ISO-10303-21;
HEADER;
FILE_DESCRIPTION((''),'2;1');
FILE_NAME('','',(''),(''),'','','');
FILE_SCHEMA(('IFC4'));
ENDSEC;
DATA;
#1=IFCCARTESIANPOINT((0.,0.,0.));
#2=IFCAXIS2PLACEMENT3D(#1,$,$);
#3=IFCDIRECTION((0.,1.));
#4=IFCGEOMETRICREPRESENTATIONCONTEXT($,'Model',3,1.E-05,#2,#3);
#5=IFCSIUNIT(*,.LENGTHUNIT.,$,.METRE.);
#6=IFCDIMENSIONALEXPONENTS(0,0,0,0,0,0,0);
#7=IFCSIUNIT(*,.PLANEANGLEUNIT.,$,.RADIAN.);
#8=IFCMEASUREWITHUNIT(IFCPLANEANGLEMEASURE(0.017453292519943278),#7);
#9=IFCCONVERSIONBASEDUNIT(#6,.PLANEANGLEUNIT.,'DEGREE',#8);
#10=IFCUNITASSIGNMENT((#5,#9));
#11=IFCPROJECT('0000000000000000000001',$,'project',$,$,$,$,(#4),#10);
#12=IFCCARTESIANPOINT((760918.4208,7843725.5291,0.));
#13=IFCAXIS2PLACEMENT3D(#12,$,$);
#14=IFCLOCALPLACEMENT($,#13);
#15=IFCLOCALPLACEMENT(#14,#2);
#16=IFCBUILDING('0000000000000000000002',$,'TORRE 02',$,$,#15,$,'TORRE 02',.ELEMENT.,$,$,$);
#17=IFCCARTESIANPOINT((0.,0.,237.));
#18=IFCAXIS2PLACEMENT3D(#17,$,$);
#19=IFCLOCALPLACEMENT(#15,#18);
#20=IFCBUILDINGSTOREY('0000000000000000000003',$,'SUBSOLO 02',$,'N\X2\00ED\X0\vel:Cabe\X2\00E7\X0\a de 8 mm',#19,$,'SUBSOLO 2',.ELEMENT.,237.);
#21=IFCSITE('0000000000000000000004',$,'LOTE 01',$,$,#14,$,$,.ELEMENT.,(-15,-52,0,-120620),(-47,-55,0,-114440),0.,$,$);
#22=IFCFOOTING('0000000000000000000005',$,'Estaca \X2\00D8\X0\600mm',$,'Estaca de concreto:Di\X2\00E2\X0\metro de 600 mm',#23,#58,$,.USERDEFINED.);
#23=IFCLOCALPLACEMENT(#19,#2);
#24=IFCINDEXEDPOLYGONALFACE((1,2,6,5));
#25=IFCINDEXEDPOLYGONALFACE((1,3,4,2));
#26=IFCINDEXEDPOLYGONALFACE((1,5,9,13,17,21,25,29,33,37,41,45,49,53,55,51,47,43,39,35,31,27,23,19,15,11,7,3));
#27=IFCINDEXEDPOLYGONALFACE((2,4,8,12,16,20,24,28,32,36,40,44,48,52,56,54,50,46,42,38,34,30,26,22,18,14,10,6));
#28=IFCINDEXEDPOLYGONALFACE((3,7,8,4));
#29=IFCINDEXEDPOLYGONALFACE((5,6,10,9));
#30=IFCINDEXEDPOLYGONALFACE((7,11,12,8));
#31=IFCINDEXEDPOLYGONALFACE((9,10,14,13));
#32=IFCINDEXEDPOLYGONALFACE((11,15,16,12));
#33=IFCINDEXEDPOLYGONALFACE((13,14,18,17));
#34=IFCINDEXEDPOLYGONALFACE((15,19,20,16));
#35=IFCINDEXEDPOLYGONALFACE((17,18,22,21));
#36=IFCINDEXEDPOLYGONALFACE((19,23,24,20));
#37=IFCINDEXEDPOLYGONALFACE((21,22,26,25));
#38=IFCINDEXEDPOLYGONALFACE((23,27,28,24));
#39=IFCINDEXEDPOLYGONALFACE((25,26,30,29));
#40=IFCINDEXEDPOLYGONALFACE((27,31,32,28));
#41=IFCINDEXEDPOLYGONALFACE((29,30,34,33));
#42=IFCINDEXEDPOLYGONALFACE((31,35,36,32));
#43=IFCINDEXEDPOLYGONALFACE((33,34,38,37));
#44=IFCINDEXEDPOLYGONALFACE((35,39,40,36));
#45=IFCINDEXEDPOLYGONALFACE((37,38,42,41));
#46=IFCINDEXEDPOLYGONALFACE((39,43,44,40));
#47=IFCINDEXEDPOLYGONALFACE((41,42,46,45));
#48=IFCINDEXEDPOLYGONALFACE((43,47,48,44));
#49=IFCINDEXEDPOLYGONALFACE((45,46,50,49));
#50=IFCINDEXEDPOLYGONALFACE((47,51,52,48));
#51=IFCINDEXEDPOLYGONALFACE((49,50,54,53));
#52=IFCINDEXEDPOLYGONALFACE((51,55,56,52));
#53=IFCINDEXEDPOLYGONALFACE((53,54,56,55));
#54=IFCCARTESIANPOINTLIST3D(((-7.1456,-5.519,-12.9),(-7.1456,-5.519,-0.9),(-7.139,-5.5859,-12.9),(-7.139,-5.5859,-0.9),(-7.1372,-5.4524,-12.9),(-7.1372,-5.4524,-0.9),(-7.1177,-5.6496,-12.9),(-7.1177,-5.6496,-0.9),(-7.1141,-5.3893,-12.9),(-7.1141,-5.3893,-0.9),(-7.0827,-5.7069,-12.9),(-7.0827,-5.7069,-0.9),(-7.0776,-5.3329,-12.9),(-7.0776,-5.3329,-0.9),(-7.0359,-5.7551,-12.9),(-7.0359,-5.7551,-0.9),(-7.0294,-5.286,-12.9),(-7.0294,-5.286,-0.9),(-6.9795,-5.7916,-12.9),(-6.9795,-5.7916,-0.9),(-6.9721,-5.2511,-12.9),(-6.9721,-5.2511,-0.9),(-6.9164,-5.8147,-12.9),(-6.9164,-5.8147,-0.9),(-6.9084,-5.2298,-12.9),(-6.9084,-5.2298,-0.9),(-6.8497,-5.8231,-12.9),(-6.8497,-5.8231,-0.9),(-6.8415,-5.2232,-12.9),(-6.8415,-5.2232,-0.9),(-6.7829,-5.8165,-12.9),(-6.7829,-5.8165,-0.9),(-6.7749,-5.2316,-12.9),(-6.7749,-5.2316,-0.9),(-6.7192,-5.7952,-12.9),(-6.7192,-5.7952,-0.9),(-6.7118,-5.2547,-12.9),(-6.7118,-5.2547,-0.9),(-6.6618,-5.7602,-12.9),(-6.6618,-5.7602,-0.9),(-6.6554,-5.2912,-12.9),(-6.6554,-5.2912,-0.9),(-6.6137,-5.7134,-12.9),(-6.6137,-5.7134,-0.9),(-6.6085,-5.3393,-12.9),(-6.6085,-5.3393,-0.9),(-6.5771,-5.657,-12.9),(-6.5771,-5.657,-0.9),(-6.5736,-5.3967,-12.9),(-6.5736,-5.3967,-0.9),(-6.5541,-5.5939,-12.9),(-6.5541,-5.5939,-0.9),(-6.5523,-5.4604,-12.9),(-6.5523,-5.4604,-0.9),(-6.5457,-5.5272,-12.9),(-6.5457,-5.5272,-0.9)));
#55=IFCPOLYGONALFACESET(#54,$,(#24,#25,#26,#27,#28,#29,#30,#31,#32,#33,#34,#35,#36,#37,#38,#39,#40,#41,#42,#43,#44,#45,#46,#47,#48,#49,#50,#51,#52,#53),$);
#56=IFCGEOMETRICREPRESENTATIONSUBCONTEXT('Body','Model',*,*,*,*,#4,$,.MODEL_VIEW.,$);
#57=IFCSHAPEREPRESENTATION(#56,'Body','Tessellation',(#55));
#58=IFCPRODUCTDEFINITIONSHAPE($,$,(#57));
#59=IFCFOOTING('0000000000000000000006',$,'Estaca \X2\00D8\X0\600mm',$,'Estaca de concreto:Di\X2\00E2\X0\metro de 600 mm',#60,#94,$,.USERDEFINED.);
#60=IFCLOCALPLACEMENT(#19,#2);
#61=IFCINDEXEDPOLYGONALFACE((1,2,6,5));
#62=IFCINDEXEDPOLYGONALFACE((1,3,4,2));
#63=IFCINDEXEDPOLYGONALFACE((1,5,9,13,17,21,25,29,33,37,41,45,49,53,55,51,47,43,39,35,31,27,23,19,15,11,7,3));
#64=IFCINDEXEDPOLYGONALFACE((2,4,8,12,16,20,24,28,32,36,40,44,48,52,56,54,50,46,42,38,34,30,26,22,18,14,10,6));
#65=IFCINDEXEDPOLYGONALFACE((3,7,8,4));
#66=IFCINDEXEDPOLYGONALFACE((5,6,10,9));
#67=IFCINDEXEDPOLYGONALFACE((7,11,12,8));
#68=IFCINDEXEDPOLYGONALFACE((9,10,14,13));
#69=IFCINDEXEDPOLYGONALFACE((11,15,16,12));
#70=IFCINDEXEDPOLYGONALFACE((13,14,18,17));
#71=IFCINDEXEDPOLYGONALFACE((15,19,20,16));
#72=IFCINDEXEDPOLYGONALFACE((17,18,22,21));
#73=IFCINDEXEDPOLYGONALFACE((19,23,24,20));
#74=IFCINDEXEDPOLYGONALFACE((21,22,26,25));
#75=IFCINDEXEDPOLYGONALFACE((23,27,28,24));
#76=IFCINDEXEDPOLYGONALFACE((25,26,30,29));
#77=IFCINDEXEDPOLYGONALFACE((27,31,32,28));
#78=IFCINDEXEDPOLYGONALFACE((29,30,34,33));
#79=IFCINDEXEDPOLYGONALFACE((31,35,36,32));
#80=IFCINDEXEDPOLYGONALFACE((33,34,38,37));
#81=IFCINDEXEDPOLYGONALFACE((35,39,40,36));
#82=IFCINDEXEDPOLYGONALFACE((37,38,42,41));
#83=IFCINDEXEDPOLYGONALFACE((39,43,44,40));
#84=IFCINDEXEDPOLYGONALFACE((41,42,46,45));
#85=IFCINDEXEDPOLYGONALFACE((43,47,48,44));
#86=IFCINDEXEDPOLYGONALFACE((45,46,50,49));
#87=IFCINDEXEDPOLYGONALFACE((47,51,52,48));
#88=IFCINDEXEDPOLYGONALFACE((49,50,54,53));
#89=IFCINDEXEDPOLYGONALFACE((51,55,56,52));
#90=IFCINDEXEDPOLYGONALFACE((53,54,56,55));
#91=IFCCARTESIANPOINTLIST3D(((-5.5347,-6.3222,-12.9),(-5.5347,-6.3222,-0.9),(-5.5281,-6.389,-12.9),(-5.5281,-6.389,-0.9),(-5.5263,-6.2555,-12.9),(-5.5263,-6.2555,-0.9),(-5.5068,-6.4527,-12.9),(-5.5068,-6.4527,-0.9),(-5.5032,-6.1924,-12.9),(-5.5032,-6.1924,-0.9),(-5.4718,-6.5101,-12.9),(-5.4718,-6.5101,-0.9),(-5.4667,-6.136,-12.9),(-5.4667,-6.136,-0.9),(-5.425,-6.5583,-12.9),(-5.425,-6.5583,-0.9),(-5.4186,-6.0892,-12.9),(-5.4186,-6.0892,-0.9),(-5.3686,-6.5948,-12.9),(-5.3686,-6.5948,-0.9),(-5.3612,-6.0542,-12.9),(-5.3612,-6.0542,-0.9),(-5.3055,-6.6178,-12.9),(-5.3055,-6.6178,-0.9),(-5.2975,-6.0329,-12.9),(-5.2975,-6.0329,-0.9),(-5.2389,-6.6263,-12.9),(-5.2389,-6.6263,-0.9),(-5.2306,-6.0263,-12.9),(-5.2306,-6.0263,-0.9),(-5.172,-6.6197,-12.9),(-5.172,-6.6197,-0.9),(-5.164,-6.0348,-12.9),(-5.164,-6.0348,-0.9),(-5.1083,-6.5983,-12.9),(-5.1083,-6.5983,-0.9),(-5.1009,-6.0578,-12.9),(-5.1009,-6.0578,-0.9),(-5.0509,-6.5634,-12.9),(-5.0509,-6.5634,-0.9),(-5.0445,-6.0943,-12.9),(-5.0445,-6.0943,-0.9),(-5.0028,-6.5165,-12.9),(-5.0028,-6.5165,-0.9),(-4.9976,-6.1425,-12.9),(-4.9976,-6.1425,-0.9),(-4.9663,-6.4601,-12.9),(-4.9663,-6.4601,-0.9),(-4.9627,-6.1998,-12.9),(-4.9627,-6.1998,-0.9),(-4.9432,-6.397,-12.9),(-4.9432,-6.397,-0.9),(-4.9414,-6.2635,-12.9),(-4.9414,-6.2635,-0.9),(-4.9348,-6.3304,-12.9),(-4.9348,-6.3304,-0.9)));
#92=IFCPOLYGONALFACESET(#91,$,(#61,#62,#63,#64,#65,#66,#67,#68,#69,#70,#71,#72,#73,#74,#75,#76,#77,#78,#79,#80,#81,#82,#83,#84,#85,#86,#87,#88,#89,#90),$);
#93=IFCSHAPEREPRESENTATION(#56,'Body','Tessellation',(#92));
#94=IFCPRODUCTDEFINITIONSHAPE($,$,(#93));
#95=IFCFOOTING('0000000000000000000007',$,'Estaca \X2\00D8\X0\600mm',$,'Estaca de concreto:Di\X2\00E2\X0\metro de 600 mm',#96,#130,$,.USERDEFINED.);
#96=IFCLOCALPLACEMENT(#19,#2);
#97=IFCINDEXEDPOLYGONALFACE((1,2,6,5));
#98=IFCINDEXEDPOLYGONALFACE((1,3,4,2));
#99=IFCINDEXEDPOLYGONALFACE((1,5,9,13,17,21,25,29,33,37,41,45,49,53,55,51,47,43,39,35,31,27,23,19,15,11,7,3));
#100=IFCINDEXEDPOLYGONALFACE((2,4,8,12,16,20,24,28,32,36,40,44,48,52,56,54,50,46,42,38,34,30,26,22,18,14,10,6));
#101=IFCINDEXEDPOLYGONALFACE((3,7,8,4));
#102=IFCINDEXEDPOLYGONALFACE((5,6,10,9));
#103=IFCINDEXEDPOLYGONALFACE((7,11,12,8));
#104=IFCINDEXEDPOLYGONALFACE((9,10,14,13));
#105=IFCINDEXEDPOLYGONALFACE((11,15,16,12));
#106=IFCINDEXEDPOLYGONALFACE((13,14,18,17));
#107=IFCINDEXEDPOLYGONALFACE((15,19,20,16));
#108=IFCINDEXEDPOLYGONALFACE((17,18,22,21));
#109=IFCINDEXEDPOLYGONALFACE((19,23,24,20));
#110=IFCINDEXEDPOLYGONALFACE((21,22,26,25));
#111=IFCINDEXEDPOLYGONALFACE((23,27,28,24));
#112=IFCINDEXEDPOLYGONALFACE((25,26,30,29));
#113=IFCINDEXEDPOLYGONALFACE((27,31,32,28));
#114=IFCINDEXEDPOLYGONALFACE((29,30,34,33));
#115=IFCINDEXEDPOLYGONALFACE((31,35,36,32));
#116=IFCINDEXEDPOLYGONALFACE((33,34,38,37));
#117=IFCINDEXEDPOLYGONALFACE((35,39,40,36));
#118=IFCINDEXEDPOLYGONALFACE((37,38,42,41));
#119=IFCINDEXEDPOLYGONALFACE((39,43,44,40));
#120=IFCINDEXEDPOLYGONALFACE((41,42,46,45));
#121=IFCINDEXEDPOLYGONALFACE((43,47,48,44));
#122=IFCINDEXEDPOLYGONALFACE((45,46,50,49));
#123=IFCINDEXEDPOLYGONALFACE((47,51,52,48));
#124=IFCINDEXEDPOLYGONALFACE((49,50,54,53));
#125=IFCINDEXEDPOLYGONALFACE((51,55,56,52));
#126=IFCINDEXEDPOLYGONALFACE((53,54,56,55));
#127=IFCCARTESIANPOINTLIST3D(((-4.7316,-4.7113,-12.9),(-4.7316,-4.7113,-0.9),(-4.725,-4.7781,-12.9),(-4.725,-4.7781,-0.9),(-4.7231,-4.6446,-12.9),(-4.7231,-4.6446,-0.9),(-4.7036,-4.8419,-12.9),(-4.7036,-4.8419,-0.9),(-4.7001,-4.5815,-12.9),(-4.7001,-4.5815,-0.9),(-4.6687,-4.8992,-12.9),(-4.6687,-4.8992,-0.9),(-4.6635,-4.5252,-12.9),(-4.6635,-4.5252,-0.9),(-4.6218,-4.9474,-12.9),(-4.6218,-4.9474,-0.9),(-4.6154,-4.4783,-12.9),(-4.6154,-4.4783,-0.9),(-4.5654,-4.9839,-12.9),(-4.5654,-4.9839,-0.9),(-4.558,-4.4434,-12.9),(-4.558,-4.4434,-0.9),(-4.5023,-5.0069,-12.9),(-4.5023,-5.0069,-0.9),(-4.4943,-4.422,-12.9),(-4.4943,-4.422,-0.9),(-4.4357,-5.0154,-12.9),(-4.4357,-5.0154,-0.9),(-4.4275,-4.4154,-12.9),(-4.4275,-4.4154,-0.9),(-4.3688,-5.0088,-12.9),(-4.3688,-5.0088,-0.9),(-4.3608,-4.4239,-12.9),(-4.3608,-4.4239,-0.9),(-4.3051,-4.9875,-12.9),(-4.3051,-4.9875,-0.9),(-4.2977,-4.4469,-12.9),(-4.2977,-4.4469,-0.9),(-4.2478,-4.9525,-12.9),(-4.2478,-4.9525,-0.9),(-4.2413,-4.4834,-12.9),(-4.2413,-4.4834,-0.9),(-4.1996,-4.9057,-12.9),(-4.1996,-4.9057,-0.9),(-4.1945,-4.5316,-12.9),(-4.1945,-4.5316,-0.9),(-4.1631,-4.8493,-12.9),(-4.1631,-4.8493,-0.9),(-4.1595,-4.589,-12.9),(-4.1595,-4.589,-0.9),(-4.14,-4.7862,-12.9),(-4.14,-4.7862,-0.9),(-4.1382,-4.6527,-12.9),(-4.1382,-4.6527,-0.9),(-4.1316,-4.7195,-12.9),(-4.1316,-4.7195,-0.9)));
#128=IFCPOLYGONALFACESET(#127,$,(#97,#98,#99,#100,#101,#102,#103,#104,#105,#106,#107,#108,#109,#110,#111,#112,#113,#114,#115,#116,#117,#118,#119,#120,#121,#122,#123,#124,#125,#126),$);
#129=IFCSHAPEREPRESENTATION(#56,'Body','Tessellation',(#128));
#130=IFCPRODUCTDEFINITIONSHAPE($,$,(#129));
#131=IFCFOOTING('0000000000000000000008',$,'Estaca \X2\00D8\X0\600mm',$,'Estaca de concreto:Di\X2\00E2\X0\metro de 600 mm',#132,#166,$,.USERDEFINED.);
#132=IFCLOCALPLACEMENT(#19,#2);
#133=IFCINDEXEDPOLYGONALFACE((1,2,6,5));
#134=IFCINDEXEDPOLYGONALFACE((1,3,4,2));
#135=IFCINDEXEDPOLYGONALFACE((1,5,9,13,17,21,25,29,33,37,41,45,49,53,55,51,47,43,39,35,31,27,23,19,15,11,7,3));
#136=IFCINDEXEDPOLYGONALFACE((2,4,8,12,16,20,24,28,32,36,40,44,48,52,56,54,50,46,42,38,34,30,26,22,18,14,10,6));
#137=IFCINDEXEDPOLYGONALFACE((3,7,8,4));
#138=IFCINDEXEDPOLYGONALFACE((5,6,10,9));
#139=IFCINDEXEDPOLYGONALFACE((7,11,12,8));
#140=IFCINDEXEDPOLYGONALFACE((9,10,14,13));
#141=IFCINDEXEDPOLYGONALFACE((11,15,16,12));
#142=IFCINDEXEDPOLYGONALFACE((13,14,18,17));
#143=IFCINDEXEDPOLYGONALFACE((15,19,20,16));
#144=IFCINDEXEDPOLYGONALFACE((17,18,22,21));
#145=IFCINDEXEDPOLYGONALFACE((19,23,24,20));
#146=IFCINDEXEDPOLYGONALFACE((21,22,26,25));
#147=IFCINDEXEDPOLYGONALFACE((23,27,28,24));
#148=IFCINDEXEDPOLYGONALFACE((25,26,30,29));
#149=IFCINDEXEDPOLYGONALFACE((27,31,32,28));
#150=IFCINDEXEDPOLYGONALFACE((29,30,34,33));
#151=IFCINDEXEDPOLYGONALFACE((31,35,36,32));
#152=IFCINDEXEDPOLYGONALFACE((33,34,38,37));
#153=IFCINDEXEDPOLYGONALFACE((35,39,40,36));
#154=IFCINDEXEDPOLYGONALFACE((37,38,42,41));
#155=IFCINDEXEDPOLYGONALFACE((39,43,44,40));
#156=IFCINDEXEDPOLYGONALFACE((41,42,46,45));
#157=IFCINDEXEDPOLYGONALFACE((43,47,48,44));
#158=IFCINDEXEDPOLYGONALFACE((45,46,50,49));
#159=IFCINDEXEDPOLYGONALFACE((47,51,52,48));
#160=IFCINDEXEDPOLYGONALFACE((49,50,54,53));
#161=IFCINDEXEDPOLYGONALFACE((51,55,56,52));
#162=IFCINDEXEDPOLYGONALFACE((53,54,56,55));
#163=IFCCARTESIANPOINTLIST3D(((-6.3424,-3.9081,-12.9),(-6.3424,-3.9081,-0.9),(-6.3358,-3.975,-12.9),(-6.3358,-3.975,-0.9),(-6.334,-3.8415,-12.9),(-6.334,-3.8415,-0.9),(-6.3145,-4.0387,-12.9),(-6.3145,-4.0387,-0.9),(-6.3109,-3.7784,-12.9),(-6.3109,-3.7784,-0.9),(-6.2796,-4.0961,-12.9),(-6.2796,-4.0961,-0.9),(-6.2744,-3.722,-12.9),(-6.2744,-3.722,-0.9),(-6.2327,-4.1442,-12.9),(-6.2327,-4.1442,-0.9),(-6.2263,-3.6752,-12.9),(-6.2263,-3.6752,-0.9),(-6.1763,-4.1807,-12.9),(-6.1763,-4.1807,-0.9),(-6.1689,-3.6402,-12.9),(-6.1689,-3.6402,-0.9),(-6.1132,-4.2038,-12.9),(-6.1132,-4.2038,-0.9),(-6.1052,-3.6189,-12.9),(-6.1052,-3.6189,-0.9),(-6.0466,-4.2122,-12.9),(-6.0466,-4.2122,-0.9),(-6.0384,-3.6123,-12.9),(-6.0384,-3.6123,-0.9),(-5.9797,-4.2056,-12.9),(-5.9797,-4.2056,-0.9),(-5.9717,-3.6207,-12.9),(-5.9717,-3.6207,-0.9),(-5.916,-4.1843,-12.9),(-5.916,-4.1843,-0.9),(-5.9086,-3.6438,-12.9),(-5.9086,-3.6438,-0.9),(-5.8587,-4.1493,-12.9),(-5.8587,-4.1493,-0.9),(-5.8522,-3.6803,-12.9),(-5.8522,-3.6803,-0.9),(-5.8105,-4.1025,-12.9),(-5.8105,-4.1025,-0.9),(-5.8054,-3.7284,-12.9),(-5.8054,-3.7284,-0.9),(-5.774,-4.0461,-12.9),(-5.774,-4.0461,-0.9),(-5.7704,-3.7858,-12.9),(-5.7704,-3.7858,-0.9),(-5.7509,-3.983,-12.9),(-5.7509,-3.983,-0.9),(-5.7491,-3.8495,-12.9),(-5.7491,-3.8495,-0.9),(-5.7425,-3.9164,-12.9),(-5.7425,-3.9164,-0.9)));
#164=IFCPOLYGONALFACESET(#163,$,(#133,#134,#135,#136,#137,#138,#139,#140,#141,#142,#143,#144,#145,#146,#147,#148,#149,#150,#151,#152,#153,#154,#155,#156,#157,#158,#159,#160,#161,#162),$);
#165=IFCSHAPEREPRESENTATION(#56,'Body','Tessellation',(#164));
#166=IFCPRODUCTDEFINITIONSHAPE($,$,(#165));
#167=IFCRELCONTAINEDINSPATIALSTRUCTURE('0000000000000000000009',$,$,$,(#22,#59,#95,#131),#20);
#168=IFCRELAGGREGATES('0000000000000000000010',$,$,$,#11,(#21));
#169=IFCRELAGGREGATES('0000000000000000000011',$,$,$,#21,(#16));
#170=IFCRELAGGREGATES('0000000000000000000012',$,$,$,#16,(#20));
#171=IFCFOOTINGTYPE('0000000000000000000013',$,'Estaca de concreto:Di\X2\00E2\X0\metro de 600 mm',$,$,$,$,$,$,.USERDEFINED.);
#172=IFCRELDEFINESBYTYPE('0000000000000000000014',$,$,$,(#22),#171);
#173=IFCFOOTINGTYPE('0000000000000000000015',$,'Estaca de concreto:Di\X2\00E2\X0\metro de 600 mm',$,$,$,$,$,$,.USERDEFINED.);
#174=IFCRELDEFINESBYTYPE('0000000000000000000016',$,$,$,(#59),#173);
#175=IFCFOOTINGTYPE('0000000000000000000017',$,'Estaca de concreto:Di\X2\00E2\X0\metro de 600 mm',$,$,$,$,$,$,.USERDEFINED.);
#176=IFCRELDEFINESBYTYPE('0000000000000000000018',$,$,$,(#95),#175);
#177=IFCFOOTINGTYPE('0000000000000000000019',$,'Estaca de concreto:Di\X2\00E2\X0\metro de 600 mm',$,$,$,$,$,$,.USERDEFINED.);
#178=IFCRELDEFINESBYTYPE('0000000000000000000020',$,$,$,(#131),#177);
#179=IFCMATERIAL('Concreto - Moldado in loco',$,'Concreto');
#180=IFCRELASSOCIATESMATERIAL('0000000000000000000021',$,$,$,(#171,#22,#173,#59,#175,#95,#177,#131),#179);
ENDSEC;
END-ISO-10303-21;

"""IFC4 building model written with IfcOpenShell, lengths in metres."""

from ifc_helpers import new_model, entity, si_unit, converted_unit, direction, frame, origin, place, context, subcontext, project, spatial, arc, indexed_curve, outline, extrude, source, transform, mapped, material, type_object, type_shapes, element, save


model = new_model("IFC4")

# Units and contexts
model_context = context("Model", 3, precision=1e-05, world=origin(), true_north=direction((0.0, 1.0)))
body_context = subcontext(model_context, "Body", "Model", "MODEL_VIEW")
ifc_project = project(units=[si_unit("LENGTHUNIT", "METRE"), converted_unit("PLANEANGLEUNIT", "DEGREE", entity("IfcPlaneAngleMeasure", 0.017453292519943278), si_unit("PLANEANGLEUNIT", "RADIAN"), dimensions=[0, 0, 0, 0, 0, 0, 0])], contexts=[model_context])

# Site, building, storey
site_placement = place(None, frame((760918.4208, 7843725.5291, 0.0)))
site = spatial("IfcSite", under=ifc_project, at=site_placement, Name="LOTE 01", CompositionType="ELEMENT", RefLatitude=(-15, -52, 0, -120620), RefLongitude=(-47, -55, 0, -114440), RefElevation=0.0)
building_placement = place(site_placement, origin())
building = spatial("IfcBuilding", under=site, at=building_placement, Name="TORRE 02", LongName="TORRE 02", CompositionType="ELEMENT")
storey_placement = place(building_placement, frame((0.0, 0.0, 237.0)))
storey = spatial("IfcBuildingStorey", under=building, at=storey_placement, Name="SUBSOLO 02", ObjectType="Nível:Cabeça de 8 mm", LongName="SUBSOLO 2", CompositionType="ELEMENT", Elevation=237.0)

# Footings
ifc_material_1 = material(Name="Concreto - Moldado in loco", Category="Concreto")
placement = place(building_placement, frame((0.0, 0.0, 237.0)))
footing_type_1 = type_object("IfcFootingType", Name="Estaca de concreto:Diâmetro de 600 mm", PredefinedType="USERDEFINED", material=ifc_material_1)
shared_shape_1 = source(origin(), body_context, "Body", "SweptSolid", [
    extrude(outline(indexed_curve([(-0.3, 0.0), (0.0, -0.3), (0.3, 0.0), (0.0, 0.3)], segments=[arc(1, 2, 3), arc(3, 4, 1)], self_intersect=False)), frame((-6.8456, -5.5231, -12.0), z_axis=(0.0, 0.0, 1.0), x_axis=(0.894934, -0.446198, 0.0)), (0.0, 0.0, 1.0), 12.0),
])
type_shapes(footing_type_1, [shared_shape_1])
footing_1_placement = place(placement, frame((0.0, 0.0, -0.9)))
element("IfcFooting", 1, at=footing_1_placement, inside=storey, type_object=footing_type_1, material=ifc_material_1, Name="Estaca Ø600mm", ObjectType="Estaca de concreto:Diâmetro de 600 mm", PredefinedType="USERDEFINED", context=body_context, shape_type="MappedRepresentation", body=[
    mapped(shared_shape_1, transform((0.0, 0.0, 0.0), scale=1.0)),
])
footing_type_2 = type_object("IfcFootingType", Name="Estaca de concreto:Diâmetro de 600 mm", PredefinedType="USERDEFINED", material=ifc_material_1)
shared_shape_2 = source(origin(), body_context, "Body", "SweptSolid", [
    extrude(outline(indexed_curve([(-0.3, 0.0), (0.0, -0.3), (0.3, 0.0), (0.0, 0.3)], segments=[arc(1, 2, 3), arc(3, 4, 1)], self_intersect=False)), frame((-5.2347, -6.3263, -12.0), z_axis=(0.0, 0.0, 1.0), x_axis=(0.894934, -0.446198, 0.0)), (0.0, 0.0, 1.0), 12.0),
])
type_shapes(footing_type_2, [shared_shape_2])
footing_2_placement = place(placement, frame((0.0, 0.0, -0.9)))
element("IfcFooting", 2, at=footing_2_placement, inside=storey, type_object=footing_type_2, material=ifc_material_1, Name="Estaca Ø600mm", ObjectType="Estaca de concreto:Diâmetro de 600 mm", PredefinedType="USERDEFINED", context=body_context, shape_type="MappedRepresentation", body=[
    mapped(shared_shape_2, transform((0.0, 0.0, 0.0), scale=1.0)),
])
footing_type_3 = type_object("IfcFootingType", Name="Estaca de concreto:Diâmetro de 600 mm", PredefinedType="USERDEFINED", material=ifc_material_1)
shared_shape_3 = source(origin(), body_context, "Body", "SweptSolid", [
    extrude(outline(indexed_curve([(-0.3, 0.0), (0.0, -0.3), (0.3, 0.0), (0.0, 0.3)], segments=[arc(1, 2, 3), arc(3, 4, 1)], self_intersect=False)), frame((-4.4316, -4.7154, -12.0), z_axis=(0.0, 0.0, 1.0), x_axis=(0.894934, -0.446198, 0.0)), (0.0, 0.0, 1.0), 12.0),
])
type_shapes(footing_type_3, [shared_shape_3])
footing_3_placement = place(placement, frame((0.0, 0.0, -0.9)))
element("IfcFooting", 3, at=footing_3_placement, inside=storey, type_object=footing_type_3, material=ifc_material_1, Name="Estaca Ø600mm", ObjectType="Estaca de concreto:Diâmetro de 600 mm", PredefinedType="USERDEFINED", context=body_context, shape_type="MappedRepresentation", body=[
    mapped(shared_shape_3, transform((0.0, 0.0, 0.0), scale=1.0)),
])
footing_type_4 = type_object("IfcFootingType", Name="Estaca de concreto:Diâmetro de 600 mm", PredefinedType="USERDEFINED", material=ifc_material_1)
shared_shape_4 = source(origin(), body_context, "Body", "SweptSolid", [
    extrude(outline(indexed_curve([(-0.3, 0.0), (0.0, -0.3), (0.3, 0.0), (0.0, 0.3)], segments=[arc(1, 2, 3), arc(3, 4, 1)], self_intersect=False)), frame((-6.0425, -3.9123, -12.0), z_axis=(0.0, 0.0, 1.0), x_axis=(0.894934, -0.446198, 0.0)), (0.0, 0.0, 1.0), 12.0),
])
type_shapes(footing_type_4, [shared_shape_4])
footing_4_placement = place(placement, frame((0.0, 0.0, -0.9)))
element("IfcFooting", 4, at=footing_4_placement, inside=storey, type_object=footing_type_4, material=ifc_material_1, Name="Estaca Ø600mm", ObjectType="Estaca de concreto:Diâmetro de 600 mm", PredefinedType="USERDEFINED", context=body_context, shape_type="MappedRepresentation", body=[
    mapped(shared_shape_4, transform((0.0, 0.0, 0.0), scale=1.0)),
])

save(model, "model.ifc")
